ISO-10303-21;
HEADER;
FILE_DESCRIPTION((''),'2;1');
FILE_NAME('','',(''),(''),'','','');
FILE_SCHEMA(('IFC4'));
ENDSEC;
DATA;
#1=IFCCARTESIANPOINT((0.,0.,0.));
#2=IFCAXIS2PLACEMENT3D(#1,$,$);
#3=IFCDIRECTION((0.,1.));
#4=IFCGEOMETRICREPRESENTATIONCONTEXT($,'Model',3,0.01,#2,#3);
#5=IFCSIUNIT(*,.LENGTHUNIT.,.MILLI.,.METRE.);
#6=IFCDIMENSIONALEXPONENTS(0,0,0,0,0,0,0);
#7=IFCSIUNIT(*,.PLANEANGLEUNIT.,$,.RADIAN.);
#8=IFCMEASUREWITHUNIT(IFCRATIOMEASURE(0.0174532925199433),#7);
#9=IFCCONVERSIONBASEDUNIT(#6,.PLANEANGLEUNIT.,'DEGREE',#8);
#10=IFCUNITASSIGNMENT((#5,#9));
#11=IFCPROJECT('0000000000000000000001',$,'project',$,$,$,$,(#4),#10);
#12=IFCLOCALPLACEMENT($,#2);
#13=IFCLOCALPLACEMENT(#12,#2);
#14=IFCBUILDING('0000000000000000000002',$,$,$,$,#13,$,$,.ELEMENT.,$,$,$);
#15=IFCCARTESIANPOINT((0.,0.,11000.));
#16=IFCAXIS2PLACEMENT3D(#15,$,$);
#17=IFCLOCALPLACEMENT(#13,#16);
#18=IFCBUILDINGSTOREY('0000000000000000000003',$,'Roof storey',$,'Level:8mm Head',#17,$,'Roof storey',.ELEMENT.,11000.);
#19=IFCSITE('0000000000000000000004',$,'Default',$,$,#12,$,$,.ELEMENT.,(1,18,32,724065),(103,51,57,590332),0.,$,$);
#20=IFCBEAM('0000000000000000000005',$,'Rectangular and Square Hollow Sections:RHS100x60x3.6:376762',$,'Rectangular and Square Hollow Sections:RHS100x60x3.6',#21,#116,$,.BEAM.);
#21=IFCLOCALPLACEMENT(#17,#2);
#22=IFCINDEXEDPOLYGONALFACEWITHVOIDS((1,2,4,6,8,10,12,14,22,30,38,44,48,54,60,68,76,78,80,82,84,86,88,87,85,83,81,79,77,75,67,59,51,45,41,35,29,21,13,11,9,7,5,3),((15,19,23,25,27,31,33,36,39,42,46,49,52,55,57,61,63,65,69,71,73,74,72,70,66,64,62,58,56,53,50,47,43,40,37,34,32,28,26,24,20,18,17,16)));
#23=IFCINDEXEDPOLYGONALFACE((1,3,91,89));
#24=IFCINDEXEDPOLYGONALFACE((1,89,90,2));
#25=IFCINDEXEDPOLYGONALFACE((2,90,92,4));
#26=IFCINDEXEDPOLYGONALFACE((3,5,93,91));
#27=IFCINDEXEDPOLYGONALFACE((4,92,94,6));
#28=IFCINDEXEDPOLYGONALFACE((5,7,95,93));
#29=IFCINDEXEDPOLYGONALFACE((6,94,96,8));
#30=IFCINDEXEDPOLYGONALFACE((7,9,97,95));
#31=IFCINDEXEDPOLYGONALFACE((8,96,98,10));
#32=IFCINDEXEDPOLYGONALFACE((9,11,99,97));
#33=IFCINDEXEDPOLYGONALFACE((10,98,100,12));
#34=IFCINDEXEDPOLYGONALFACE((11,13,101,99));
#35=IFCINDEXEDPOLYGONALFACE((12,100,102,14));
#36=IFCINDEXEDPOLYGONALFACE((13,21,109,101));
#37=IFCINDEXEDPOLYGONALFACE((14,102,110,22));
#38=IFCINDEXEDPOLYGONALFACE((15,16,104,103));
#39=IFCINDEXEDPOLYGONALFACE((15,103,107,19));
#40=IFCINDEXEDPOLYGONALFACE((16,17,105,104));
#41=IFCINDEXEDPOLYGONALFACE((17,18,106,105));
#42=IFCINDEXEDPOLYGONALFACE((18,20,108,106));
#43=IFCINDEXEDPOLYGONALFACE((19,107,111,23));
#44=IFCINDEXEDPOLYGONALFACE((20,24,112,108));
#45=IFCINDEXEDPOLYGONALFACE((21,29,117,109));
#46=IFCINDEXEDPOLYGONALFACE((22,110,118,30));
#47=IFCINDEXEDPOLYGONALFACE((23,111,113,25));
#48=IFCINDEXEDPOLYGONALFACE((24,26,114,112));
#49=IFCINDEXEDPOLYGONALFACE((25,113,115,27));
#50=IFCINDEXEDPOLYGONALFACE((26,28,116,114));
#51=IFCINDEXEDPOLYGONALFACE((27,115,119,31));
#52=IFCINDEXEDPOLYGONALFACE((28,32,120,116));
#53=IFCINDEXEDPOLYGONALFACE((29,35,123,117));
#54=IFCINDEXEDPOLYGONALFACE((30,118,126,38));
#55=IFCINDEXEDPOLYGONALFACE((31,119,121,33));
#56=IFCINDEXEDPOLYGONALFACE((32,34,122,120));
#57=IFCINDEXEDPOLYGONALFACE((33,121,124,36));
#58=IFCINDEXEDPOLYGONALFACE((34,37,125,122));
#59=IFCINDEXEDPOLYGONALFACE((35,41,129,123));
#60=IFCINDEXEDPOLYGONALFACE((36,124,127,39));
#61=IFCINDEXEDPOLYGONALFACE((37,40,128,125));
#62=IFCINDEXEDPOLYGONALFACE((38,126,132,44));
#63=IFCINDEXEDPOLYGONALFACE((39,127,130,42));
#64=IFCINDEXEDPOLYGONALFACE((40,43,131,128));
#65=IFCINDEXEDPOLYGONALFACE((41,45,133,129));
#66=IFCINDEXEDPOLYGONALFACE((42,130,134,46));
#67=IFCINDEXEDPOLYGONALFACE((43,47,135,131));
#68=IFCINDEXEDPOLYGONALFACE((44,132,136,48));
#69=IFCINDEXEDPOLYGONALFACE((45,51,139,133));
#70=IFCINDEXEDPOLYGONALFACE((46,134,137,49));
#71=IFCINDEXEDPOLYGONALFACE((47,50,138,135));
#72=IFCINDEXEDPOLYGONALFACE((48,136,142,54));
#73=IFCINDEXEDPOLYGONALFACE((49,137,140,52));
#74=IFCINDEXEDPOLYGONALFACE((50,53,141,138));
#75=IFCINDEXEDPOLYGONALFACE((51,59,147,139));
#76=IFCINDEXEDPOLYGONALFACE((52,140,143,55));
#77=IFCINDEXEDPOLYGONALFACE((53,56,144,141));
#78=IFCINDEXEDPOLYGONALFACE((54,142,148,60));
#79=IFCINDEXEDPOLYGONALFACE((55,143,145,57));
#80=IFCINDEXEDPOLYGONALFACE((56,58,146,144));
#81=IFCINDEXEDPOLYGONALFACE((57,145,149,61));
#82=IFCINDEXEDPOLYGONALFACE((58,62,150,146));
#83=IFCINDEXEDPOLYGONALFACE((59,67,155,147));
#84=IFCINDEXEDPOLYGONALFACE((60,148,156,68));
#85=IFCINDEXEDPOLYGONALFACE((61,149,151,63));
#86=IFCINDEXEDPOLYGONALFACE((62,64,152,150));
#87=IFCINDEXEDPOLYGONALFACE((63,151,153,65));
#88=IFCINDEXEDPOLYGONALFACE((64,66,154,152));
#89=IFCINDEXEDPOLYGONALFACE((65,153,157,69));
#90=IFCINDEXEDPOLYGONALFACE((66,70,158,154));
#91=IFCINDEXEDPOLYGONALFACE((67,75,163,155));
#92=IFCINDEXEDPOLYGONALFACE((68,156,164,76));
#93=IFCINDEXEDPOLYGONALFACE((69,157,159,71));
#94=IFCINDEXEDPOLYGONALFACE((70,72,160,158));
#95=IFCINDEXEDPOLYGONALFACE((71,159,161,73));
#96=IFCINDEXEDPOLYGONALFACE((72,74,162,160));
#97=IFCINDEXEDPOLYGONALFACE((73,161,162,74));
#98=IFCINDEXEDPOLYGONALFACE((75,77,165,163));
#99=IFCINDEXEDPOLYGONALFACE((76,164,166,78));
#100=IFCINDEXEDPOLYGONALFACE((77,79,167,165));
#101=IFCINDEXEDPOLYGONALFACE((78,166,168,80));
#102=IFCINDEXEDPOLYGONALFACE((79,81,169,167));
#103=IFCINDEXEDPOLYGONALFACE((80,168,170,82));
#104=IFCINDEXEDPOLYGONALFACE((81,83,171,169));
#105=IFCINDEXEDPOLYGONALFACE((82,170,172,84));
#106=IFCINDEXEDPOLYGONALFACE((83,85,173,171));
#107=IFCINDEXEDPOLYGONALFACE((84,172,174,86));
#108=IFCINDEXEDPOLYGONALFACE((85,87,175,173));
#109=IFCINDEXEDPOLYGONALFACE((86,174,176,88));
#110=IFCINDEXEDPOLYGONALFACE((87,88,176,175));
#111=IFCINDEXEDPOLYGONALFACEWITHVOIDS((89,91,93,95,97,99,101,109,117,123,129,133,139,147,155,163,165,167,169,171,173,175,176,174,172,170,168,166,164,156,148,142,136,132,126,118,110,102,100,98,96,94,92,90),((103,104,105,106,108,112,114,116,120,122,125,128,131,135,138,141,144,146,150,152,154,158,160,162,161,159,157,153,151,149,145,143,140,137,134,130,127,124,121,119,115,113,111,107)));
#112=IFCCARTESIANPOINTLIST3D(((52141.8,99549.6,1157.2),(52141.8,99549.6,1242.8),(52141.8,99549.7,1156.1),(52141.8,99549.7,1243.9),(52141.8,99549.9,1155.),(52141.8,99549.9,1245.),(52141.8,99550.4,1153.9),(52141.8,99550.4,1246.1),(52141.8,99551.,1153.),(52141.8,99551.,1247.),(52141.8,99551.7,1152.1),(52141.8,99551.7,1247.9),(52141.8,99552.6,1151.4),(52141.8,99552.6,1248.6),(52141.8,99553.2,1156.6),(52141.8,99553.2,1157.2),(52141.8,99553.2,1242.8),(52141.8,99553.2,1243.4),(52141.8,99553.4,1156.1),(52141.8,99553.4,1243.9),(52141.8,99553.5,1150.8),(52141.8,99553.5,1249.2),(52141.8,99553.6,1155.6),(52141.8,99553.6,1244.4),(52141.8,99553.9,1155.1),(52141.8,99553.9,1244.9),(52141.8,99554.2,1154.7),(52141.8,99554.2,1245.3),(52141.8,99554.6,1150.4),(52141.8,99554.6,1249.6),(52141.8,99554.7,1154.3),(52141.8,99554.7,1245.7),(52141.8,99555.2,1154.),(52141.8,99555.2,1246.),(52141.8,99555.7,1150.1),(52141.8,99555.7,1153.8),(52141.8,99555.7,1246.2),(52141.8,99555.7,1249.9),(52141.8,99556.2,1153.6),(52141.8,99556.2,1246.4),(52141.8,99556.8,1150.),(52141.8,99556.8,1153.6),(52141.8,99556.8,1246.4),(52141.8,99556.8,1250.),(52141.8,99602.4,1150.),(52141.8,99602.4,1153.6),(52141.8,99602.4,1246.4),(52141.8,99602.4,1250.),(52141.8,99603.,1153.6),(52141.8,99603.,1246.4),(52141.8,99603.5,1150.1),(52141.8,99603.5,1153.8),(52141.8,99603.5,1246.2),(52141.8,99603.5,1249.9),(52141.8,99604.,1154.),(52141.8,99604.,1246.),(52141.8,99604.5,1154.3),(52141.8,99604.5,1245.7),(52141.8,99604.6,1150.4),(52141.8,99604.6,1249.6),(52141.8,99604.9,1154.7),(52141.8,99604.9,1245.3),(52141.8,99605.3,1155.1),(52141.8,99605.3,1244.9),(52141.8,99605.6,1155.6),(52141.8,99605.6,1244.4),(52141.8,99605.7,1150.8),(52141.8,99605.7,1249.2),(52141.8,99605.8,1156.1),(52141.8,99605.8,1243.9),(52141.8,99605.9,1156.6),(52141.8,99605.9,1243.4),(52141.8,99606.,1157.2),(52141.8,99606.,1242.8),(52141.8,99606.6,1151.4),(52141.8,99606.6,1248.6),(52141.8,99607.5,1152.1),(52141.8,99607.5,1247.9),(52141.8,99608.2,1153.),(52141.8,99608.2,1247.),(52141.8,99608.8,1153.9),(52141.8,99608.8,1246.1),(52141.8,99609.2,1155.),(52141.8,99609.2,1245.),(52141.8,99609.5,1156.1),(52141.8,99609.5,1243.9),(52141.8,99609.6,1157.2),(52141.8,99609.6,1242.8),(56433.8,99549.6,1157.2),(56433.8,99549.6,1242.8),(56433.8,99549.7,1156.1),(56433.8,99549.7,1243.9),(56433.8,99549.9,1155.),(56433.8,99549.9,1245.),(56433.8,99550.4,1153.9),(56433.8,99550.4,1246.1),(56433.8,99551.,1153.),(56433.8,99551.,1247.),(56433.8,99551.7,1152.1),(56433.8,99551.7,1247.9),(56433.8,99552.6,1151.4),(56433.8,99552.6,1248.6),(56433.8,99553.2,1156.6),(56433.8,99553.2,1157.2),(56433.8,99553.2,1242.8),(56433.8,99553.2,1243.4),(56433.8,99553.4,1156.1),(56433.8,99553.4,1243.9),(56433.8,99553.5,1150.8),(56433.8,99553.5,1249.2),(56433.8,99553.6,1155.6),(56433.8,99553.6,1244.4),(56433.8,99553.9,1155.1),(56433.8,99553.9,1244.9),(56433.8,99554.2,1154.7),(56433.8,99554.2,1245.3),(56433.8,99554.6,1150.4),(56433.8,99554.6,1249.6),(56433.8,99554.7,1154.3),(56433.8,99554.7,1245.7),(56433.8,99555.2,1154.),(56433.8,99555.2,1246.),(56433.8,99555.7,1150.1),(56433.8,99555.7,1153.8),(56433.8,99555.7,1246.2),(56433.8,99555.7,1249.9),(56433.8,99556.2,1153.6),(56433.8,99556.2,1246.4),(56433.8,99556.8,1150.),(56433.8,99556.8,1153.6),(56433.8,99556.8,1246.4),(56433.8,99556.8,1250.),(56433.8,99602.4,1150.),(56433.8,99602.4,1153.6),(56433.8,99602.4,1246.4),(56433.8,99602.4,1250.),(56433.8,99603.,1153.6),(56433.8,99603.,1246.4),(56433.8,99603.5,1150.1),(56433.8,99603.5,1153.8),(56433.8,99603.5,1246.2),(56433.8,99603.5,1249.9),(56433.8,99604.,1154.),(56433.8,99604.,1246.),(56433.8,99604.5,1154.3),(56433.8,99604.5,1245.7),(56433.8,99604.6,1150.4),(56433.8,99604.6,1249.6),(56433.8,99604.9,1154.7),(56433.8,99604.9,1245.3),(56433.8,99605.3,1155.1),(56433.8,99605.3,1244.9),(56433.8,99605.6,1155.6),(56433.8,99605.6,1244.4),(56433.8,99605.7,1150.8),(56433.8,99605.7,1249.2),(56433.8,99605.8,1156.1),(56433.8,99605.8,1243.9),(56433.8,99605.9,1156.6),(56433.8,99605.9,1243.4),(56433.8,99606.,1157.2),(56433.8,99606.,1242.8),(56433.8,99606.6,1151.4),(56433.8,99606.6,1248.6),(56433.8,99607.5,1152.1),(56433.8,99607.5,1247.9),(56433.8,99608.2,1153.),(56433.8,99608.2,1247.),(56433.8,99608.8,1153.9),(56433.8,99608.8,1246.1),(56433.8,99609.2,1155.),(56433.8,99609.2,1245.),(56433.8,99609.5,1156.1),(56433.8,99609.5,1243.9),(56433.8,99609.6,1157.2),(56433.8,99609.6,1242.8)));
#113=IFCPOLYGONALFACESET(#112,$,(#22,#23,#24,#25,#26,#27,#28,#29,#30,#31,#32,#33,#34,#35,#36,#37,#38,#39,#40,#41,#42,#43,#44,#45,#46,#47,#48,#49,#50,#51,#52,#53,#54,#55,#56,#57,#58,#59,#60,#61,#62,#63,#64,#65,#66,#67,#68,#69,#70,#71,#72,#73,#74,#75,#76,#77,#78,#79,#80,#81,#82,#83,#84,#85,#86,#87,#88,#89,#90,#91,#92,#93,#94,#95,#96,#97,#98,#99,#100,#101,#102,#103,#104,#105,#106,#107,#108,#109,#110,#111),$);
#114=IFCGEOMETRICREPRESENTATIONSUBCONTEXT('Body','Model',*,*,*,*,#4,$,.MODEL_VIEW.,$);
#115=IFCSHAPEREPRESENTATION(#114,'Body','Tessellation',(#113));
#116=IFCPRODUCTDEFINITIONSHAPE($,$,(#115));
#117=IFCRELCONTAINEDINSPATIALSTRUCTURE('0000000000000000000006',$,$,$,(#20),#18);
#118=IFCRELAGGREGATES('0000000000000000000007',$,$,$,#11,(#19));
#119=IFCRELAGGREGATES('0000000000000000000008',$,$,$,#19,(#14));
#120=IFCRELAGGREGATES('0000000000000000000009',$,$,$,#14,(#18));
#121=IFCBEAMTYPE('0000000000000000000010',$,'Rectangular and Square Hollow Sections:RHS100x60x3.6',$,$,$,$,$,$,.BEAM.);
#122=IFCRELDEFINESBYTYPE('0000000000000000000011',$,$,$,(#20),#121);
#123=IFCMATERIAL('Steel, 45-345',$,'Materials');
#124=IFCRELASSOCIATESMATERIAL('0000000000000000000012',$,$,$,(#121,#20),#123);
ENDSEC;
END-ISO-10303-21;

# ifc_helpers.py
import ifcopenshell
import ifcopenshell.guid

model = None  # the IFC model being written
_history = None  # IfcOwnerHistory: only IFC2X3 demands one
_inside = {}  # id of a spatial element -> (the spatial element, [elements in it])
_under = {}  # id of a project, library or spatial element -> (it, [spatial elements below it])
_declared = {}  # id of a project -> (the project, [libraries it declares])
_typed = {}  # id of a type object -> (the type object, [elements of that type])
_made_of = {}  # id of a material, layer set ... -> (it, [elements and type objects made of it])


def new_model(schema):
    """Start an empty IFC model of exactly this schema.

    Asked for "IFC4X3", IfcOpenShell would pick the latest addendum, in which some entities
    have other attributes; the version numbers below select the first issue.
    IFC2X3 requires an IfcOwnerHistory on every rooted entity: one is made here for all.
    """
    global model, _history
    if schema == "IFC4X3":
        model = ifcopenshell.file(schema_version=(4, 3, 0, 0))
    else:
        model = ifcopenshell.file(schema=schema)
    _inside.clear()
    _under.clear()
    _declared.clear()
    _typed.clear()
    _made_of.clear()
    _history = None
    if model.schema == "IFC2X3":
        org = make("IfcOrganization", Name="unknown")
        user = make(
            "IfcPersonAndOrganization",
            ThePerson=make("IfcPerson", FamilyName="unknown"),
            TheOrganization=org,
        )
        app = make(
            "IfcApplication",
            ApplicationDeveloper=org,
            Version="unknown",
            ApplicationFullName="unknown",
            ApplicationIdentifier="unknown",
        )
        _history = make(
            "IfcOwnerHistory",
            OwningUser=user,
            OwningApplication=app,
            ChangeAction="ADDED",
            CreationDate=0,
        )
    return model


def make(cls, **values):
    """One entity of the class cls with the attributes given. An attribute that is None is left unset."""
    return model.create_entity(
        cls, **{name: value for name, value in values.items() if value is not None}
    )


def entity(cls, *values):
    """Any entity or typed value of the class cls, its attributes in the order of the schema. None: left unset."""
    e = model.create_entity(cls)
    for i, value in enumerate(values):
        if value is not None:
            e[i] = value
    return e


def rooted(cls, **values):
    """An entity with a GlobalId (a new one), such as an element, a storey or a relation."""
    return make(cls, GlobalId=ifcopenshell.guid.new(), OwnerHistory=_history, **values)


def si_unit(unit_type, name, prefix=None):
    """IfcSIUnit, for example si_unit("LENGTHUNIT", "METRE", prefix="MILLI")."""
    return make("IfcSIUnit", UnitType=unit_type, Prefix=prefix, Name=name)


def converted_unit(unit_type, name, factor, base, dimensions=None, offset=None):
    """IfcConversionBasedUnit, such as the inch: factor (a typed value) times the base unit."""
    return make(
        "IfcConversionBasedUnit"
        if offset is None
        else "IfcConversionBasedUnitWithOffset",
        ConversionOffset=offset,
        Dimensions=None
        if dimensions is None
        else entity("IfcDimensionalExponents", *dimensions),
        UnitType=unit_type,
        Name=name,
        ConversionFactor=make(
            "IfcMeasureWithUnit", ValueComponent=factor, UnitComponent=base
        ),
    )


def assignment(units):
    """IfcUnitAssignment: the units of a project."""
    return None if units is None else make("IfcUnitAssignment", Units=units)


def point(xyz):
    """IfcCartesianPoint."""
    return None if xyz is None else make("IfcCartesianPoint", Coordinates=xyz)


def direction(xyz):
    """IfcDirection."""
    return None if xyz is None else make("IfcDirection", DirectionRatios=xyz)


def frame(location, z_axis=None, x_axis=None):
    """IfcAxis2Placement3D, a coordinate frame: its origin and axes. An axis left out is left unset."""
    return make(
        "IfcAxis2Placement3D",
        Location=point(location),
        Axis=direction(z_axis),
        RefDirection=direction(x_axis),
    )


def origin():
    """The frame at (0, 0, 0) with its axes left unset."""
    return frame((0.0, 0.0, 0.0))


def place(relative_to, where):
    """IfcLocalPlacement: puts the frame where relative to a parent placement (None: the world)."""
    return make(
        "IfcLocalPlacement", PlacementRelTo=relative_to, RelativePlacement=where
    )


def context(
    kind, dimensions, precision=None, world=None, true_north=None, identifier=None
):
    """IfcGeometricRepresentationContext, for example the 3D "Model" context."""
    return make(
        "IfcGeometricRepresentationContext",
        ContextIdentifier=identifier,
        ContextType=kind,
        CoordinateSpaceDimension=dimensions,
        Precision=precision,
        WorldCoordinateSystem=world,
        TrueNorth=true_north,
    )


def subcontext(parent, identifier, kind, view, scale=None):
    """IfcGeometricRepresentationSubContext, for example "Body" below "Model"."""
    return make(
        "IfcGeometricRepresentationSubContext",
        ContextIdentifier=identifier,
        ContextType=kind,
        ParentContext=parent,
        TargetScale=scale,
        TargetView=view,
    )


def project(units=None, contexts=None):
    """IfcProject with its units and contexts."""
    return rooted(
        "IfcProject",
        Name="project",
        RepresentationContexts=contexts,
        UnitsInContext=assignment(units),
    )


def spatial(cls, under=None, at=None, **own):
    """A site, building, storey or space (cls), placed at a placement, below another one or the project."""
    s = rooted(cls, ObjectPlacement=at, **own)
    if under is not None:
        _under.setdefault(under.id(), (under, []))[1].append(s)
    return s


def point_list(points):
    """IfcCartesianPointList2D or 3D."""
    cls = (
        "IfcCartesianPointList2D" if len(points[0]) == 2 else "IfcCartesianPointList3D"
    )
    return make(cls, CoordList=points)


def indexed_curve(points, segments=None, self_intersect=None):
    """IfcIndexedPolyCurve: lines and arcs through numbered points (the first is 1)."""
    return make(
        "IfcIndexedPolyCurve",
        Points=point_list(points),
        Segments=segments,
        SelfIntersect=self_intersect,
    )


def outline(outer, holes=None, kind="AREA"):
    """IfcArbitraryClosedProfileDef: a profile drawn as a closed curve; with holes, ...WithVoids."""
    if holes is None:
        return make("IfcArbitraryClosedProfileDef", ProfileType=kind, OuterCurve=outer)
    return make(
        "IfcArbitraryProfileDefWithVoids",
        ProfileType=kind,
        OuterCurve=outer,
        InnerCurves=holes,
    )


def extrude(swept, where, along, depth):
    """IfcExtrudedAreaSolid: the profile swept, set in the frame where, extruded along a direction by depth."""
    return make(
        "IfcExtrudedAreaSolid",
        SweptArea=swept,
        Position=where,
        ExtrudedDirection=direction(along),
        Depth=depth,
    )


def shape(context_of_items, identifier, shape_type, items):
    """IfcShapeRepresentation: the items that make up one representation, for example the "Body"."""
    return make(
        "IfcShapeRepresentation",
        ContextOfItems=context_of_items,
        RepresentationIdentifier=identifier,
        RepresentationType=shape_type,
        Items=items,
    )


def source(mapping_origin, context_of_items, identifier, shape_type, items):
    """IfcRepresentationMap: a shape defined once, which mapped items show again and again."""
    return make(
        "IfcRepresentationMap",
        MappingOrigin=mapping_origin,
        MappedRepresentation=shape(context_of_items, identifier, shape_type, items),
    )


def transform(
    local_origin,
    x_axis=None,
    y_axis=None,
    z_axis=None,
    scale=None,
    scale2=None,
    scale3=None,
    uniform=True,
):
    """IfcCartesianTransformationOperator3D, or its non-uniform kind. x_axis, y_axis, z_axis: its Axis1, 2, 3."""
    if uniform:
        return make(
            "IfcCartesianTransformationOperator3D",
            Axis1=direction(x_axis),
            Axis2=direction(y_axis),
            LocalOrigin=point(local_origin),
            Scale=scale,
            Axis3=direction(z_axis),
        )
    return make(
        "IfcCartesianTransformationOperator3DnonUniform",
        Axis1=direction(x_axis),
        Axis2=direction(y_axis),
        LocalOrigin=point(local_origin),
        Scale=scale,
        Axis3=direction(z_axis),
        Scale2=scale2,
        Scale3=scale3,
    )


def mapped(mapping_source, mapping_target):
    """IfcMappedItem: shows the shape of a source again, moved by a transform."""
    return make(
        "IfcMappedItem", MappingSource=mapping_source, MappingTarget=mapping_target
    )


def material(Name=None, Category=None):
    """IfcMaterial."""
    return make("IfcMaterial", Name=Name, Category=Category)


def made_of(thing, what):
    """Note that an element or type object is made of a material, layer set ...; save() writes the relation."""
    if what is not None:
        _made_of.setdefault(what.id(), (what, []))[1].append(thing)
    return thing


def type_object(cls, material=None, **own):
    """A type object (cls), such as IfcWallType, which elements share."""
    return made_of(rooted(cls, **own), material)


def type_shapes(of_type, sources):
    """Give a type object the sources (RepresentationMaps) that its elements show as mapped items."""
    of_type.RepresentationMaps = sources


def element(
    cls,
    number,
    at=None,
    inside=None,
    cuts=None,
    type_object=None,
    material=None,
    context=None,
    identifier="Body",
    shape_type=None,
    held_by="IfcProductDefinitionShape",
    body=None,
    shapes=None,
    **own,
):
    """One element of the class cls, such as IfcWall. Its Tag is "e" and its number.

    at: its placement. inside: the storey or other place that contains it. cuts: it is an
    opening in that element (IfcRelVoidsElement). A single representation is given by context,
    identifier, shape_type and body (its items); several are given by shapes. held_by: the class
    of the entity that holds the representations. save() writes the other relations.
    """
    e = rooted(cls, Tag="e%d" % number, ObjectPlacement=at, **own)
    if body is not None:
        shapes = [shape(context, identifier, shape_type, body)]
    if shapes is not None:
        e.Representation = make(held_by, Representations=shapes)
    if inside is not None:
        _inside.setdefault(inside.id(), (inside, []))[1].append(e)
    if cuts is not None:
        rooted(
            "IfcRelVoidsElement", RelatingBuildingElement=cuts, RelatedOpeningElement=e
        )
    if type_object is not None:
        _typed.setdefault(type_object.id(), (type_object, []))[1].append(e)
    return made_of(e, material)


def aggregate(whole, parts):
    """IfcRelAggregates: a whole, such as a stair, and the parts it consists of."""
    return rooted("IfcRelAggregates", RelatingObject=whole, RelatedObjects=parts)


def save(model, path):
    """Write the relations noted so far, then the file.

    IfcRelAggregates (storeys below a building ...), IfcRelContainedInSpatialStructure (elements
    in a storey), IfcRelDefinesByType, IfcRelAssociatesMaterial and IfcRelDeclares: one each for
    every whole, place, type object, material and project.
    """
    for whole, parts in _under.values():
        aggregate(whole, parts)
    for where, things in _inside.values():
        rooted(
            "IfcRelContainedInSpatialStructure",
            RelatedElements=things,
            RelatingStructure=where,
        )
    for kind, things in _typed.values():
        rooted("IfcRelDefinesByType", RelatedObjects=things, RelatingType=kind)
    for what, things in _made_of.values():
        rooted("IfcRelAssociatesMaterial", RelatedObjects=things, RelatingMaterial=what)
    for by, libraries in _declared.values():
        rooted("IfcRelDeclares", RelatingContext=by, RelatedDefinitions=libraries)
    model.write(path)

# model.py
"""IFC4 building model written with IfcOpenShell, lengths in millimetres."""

from ifc_helpers import new_model, entity, si_unit, converted_unit, direction, frame, origin, place, context, subcontext, project, spatial, indexed_curve, outline, extrude, source, transform, mapped, material, type_object, type_shapes, element, save


model = new_model("IFC4")

# Units and contexts
model_context = context("Model", 3, precision=0.01, world=origin(), true_north=direction((0.0, 1.0)))
body_context = subcontext(model_context, "Body", "Model", "MODEL_VIEW")
ifc_project = project(units=[si_unit("LENGTHUNIT", "METRE", prefix="MILLI"), converted_unit("PLANEANGLEUNIT", "DEGREE", entity("IfcRatioMeasure", 0.0174532925199433), si_unit("PLANEANGLEUNIT", "RADIAN"), dimensions=[0, 0, 0, 0, 0, 0, 0])], contexts=[model_context])

# Site, building, storey
site_placement = place(None, origin())
site = spatial("IfcSite", under=ifc_project, at=site_placement, Name="Default", CompositionType="ELEMENT", RefLatitude=(1, 18, 32, 724065), RefLongitude=(103, 51, 57, 590332), RefElevation=0.0)
building_placement = place(site_placement, origin())
building = spatial("IfcBuilding", under=site, at=building_placement, CompositionType="ELEMENT")
storey_placement = place(building_placement, frame((0.0, 0.0, 11000.0)))
storey = spatial("IfcBuildingStorey", under=building, at=storey_placement, Name="Roof storey", ObjectType="Level:8mm Head", LongName="Roof storey", CompositionType="ELEMENT", Elevation=11000.0)

# Shared definitions
ifc_material = material(Name="Steel, 45-345", Category="Materials")

# Beam
beam_type_1 = type_object("IfcBeamType", Name="Rectangular and Square Hollow Sections:RHS100x60x3.6", PredefinedType="BEAM", material=ifc_material)
shared_shape_1 = source(origin(), body_context, "Body", "SweptSolid", [
    extrude(outline(indexed_curve([(-30.0, -42.8), (-29.9, -43.9), (-29.6, -45.0), (-29.2, -46.1), (-28.6, -47.0), (-27.9, -47.9), (-27.0, -48.6), (-26.1, -49.2), (-25.0, -49.6), (-23.9, -49.9), (-22.8, -50.0), (22.8, -50.0), (23.9, -49.9), (25.0, -49.6), (26.1, -49.2), (27.0, -48.6), (27.9, -47.9), (28.6, -47.0), (29.2, -46.1), (29.6, -45.0), (29.9, -43.9), (30.0, -42.8), (30.0, 42.8), (29.9, 43.9), (29.6, 45.0), (29.2, 46.1), (28.6, 47.0), (27.9, 47.9), (27.0, 48.6), (26.1, 49.2), (25.0, 49.6), (23.9, 49.9), (22.8, 50.0), (-22.8, 50.0), (-23.9, 49.9), (-25.0, 49.6), (-26.1, 49.2), (-27.0, 48.6), (-27.9, 47.9), (-28.6, 47.0), (-29.2, 46.1), (-29.6, 45.0), (-29.9, 43.9), (-30.0, 42.8), (-30.0, -42.8)], self_intersect=False), holes=[indexed_curve([(22.8, -46.4), (-22.8, -46.4), (-23.4, -46.4), (-23.9, -46.2), (-24.4, -46.0), (-24.9, -45.7), (-25.3, -45.3), (-25.7, -44.9), (-26.0, -44.4), (-26.2, -43.9), (-26.4, -43.4), (-26.4, -42.8), (-26.4, 42.8), (-26.4, 43.4), (-26.2, 43.9), (-26.0, 44.4), (-25.7, 44.9), (-25.3, 45.3), (-24.9, 45.7), (-24.4, 46.0), (-23.9, 46.2), (-23.4, 46.4), (-22.8, 46.4), (22.8, 46.4), (23.4, 46.4), (23.9, 46.2), (24.4, 46.0), (24.9, 45.7), (25.3, 45.3), (25.7, 44.9), (26.0, 44.4), (26.2, 43.9), (26.4, 43.4), (26.4, 42.8), (26.4, -42.8), (26.4, -43.4), (26.2, -43.9), (26.0, -44.4), (25.7, -44.9), (25.3, -45.3), (24.9, -45.7), (24.4, -46.0), (23.9, -46.2), (23.4, -46.4), (22.8, -46.4)], self_intersect=False)]), frame((-2152.5, 0.0, 0.0), z_axis=(1.0, 0.0, 0.0), x_axis=(0.0, -1.0, 0.0)), (0.0, 0.0, 1.0), 4292.0),
])
type_shapes(beam_type_1, [shared_shape_1])
for number, where, name in (
    (1, (54294.3, 99579.6, 1200.0), "Rectangular and Square Hollow Sections:RHS100x60x3.6:376762"),
):
    element("IfcBeam", number, at=place(storey_placement, frame(where)), inside=storey, type_object=beam_type_1, material=ifc_material, Name=name, ObjectType="Rectangular and Square Hollow Sections:RHS100x60x3.6", PredefinedType="BEAM", context=body_context, shape_type="MappedRepresentation", body=[
        mapped(shared_shape_1, transform((0.0, 0.0, 0.0), scale=1.0)),
    ])

save(model, "model.ifc")
